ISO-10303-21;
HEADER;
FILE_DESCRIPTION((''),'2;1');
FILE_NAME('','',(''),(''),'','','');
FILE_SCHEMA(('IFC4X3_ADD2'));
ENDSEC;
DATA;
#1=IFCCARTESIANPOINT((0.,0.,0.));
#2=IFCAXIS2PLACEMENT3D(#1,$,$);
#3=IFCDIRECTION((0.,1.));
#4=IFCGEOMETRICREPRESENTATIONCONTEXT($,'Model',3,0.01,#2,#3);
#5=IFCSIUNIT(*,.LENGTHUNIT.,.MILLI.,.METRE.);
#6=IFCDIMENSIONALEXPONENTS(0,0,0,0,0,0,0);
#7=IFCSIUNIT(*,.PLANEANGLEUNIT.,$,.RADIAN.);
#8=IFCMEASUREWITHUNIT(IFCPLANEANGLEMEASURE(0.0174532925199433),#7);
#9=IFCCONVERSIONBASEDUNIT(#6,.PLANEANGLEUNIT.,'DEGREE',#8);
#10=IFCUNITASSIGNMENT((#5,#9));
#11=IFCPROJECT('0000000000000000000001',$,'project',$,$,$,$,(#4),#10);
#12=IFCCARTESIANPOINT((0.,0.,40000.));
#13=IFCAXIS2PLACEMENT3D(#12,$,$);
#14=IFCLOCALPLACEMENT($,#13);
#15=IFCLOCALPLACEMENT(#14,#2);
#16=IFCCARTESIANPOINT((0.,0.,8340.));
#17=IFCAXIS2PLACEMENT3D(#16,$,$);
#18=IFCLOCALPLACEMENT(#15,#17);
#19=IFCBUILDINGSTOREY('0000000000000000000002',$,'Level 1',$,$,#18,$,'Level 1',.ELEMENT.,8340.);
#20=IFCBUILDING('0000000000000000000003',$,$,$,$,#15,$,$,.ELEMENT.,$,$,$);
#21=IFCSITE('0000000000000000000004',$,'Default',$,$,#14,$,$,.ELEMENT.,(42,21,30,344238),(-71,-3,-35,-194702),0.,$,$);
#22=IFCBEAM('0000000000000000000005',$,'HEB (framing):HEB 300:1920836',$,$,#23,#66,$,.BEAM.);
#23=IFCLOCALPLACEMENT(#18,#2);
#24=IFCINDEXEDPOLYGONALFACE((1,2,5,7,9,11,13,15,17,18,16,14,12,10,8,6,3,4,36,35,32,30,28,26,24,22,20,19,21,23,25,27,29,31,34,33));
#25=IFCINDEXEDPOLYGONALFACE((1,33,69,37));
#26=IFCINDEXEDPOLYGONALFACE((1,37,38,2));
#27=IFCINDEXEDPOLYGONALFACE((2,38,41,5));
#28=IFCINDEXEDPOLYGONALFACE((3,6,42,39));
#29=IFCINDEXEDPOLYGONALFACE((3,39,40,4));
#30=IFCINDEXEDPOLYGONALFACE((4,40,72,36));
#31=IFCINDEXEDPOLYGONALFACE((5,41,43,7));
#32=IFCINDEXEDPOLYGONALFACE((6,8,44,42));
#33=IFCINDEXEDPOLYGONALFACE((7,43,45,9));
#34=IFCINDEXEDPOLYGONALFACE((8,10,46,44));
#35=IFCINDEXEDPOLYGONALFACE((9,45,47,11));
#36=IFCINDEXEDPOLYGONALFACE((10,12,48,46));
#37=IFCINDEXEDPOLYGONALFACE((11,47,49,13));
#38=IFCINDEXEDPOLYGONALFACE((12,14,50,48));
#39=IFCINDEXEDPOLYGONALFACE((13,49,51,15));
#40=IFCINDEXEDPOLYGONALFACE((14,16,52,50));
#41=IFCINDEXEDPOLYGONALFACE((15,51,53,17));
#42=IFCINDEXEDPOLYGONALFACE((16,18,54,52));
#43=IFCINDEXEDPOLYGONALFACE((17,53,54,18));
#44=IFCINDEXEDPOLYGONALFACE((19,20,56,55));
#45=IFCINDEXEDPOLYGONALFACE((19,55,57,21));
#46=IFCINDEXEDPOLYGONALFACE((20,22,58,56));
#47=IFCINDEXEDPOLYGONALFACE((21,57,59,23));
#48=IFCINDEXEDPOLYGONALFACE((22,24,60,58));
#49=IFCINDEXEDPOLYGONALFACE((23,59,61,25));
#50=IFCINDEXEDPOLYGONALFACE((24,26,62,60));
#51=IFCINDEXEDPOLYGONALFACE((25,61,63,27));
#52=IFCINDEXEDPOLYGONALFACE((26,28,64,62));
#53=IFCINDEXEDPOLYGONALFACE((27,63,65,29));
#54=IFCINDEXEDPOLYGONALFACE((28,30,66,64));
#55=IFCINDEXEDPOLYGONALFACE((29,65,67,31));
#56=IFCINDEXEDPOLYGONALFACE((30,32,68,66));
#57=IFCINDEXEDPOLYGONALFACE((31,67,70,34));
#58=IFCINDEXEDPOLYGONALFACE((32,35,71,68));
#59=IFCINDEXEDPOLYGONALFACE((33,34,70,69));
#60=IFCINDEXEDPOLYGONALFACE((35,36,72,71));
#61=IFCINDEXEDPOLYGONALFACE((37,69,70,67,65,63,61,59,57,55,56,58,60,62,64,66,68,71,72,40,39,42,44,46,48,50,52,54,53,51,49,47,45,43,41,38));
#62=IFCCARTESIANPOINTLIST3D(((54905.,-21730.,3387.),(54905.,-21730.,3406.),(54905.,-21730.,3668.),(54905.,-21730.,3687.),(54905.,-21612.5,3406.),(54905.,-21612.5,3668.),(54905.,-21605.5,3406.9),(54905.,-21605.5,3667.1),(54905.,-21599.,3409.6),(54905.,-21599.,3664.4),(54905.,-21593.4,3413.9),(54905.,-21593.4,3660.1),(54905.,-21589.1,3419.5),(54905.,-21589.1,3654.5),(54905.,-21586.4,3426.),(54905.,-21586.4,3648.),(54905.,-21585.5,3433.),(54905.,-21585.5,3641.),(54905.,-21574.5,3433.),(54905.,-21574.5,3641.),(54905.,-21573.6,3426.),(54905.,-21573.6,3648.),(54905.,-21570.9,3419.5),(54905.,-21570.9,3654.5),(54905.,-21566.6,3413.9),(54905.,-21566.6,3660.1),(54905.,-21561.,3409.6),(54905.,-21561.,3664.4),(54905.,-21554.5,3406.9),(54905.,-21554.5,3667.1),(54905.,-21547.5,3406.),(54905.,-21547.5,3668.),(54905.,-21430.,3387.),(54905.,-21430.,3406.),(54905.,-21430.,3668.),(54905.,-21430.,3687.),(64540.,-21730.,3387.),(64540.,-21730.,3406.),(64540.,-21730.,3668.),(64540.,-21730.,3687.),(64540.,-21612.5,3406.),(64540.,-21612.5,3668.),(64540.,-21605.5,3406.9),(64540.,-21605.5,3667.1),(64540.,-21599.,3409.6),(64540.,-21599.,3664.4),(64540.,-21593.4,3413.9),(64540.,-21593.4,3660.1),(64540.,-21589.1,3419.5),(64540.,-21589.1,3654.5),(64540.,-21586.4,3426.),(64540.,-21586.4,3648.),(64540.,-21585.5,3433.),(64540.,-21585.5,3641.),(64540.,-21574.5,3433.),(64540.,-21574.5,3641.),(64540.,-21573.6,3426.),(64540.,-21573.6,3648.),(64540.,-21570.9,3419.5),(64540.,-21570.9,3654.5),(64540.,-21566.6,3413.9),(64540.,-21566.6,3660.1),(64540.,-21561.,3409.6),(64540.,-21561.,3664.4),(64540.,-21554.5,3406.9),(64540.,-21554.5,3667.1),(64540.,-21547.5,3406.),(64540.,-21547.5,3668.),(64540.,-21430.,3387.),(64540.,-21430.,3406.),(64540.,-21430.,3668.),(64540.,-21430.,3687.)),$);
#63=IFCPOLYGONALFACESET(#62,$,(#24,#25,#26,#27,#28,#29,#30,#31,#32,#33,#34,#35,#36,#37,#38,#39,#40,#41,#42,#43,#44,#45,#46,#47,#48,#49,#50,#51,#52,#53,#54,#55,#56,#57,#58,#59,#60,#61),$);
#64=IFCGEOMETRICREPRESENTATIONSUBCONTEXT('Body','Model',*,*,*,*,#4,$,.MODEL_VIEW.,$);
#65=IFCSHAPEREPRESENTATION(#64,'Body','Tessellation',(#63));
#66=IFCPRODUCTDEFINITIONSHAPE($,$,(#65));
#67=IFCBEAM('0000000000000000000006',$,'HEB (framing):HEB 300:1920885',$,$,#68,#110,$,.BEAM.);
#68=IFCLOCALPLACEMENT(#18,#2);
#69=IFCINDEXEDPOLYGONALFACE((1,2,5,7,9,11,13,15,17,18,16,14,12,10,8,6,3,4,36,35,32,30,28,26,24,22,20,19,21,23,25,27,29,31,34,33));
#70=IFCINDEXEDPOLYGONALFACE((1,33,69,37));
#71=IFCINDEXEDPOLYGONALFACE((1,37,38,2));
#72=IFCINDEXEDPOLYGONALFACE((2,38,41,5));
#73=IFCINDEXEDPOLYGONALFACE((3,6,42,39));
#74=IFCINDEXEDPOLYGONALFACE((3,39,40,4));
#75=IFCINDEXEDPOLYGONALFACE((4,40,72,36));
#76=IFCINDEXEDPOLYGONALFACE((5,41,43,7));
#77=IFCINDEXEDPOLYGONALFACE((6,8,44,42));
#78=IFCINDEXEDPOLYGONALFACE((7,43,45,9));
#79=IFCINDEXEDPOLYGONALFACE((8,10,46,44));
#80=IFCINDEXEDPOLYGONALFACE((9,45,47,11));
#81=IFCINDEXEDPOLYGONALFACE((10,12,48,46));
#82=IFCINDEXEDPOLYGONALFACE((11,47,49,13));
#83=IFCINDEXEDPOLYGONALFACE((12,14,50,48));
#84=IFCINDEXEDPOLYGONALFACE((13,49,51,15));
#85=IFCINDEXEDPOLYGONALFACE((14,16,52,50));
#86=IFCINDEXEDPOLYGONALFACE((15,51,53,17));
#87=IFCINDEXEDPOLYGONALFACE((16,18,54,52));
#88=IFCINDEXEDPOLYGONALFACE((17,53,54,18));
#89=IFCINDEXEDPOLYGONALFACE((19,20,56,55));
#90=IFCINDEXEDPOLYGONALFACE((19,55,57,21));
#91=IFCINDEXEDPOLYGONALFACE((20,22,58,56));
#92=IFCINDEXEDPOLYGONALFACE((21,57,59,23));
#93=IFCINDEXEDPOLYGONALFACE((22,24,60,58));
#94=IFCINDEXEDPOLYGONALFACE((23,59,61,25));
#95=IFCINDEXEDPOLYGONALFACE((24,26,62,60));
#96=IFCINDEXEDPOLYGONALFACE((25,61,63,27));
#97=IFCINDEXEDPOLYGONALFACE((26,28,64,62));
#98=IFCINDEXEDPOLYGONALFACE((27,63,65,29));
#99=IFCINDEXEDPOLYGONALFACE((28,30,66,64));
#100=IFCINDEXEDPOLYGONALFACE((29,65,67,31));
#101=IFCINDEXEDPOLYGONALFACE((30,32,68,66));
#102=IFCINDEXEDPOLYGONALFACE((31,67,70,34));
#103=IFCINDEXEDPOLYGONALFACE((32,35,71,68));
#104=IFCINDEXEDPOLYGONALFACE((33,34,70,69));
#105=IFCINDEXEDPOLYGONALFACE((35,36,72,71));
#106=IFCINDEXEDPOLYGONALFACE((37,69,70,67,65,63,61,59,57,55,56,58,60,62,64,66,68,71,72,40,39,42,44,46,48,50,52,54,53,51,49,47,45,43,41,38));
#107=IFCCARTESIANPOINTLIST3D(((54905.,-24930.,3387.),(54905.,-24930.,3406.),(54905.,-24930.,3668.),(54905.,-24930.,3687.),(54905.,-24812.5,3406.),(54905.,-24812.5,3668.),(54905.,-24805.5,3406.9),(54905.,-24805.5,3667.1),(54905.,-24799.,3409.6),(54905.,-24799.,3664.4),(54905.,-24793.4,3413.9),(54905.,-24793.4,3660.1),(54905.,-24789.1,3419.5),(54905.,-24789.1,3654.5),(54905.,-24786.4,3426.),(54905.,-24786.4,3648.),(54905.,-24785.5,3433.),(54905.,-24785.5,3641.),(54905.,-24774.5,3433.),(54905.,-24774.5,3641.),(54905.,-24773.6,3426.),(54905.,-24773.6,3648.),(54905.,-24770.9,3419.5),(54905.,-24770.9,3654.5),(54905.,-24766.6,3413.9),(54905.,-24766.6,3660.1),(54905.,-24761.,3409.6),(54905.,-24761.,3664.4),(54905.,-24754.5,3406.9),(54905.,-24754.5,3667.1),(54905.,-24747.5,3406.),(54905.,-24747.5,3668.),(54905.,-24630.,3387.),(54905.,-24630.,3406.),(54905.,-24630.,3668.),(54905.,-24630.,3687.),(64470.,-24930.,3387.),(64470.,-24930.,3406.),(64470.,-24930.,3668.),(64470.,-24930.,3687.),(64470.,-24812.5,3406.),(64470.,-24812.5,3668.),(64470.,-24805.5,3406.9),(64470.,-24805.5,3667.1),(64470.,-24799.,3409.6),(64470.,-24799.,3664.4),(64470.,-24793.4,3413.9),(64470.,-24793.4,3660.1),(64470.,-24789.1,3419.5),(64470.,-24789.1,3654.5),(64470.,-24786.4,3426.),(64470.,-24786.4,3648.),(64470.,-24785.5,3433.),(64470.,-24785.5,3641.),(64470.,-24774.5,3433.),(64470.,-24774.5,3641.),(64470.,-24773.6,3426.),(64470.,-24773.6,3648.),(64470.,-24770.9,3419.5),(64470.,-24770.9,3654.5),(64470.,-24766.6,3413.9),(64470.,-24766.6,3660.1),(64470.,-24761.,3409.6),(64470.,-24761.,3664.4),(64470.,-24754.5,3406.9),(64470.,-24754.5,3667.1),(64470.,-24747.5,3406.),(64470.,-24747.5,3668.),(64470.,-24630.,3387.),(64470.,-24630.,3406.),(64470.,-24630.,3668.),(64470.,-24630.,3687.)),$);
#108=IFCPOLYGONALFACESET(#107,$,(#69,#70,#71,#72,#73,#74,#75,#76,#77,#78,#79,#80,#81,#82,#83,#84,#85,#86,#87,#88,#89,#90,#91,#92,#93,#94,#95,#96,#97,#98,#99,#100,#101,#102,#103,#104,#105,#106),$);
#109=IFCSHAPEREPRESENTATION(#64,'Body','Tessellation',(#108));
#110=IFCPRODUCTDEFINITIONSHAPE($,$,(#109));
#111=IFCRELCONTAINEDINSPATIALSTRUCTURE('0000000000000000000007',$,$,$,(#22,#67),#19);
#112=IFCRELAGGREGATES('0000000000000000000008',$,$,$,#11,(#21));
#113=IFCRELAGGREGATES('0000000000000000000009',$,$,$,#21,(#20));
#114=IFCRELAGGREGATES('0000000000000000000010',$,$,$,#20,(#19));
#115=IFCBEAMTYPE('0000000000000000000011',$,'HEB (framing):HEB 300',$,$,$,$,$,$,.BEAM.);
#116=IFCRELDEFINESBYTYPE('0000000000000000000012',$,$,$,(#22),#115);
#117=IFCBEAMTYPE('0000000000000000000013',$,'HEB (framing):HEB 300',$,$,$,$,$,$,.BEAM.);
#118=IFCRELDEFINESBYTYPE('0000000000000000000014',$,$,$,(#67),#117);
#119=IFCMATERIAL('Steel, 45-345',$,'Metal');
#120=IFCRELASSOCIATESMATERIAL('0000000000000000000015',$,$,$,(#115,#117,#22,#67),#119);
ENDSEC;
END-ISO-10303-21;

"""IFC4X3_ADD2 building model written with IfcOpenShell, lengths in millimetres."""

from ifc_helpers import new_model, entity, si_unit, converted_unit, direction, frame, frame_2d, origin, place, context, subcontext, project, spatial, polyline, circle_curve, parameter, trimmed, segment, composite_curve, outline, extrude, source, transform, mapped, material, material_profile, profile_set, profile_usage, type_object, type_shapes, element, save


model = new_model("IFC4X3_ADD2")

# Units and contexts
model_context = context("Model", 3, precision=0.01, world=origin(), true_north=direction((0.0, 1.0)))
body_context = subcontext(model_context, "Body", "Model", "MODEL_VIEW")
ifc_project = project(units=[si_unit("LENGTHUNIT", "METRE", prefix="MILLI"), converted_unit("PLANEANGLEUNIT", "DEGREE", entity("IfcPlaneAngleMeasure", 0.0174532925199433), si_unit("PLANEANGLEUNIT", "RADIAN"), dimensions=[0, 0, 0, 0, 0, 0, 0])], contexts=[model_context])

# Site, building, storey
site_placement = place(None, frame((0.0, 0.0, 40000.0)))
site = spatial("IfcSite", under=ifc_project, at=site_placement, Name="Default", CompositionType="ELEMENT", RefLatitude=(42, 21, 30, 344238), RefLongitude=(-71, -3, -35, -194702), RefElevation=0.0)
building_placement = place(site_placement, origin())
building = spatial("IfcBuilding", under=site, at=building_placement, CompositionType="ELEMENT")
storey_placement = place(building_placement, frame((0.0, 0.0, 8340.0)))
storey = spatial("IfcBuildingStorey", under=building, at=storey_placement, Name="Level 1", LongName="Level 1", CompositionType="ELEMENT", Elevation=8340.0)

# Shared definitions
ifc_material_1 = material(Name="Steel, 45-345", Category="Metal")

# Beams
ifc_material_profile_1 = material_profile(ifc_material_1, outline(composite_curve([segment(polyline([(-150.0, -131.0), (-150.0, -150.0)]), True, "CONTINUOUS"), segment(polyline([(-150.0, -150.0), (150.0, -150.0)]), True, "CONTINUOUS"), segment(polyline([(150.0, -150.0), (150.0, -131.0)]), True, "CONTINUOUS"), segment(polyline([(150.0, -131.0), (32.5, -131.0)]), True, "CONTINUOUS"), segment(trimmed(circle_curve(frame_2d((32.5, -104.0), x_axis=(1.0, 0.0)), 27.0), [parameter(180.0)], [parameter(270.0)], True, "PARAMETER"), False, "CONTINUOUS"), segment(polyline([(5.5, -104.0), (5.5, 104.0)]), True, "CONTINUOUS"), segment(trimmed(circle_curve(frame_2d((32.5, 104.0), x_axis=(1.0, 0.0)), 27.0), [parameter(90.0)], [parameter(180.0)], True, "PARAMETER"), False, "CONTINUOUS"), segment(polyline([(32.5, 131.0), (150.0, 131.0)]), True, "CONTINUOUS"), segment(polyline([(150.0, 131.0), (150.0, 150.0)]), True, "CONTINUOUS"), segment(polyline([(150.0, 150.0), (-150.0, 150.0)]), True, "CONTINUOUS"), segment(polyline([(-150.0, 150.0), (-150.0, 131.0)]), True, "CONTINUOUS"), segment(polyline([(-150.0, 131.0), (-32.5, 131.0)]), True, "CONTINUOUS"), segment(trimmed(circle_curve(frame_2d((-32.5, 104.0), x_axis=(1.0, 0.0)), 27.0), [parameter(360.0)], [parameter(90.0)], True, "PARAMETER"), False, "CONTINUOUS"), segment(polyline([(-5.5, 104.0), (-5.5, -104.0)]), True, "CONTINUOUS"), segment(trimmed(circle_curve(frame_2d((-32.5, -104.0), x_axis=(1.0, 0.0)), 27.0), [parameter(270.0)], [parameter(0.0)], True, "PARAMETER"), False, "CONTINUOUS"), segment(polyline([(-32.5, -131.0), (-150.0, -131.0)]), True, "CONTINUOUS")], self_intersect=False)), Name="HEB 300")
ifc_profile_set_1 = profile_set([ifc_material_profile_1], Name="HEB 300")
ifc_profile_usage_1 = profile_usage(ifc_profile_set_1, cardinal=8)
beam_type_1 = type_object("IfcBeamType", Name="HEB (framing):HEB 300", PredefinedType="BEAM", material=ifc_profile_set_1)
shared_shape_1 = source(origin(), body_context, "Body", "SweptSolid", [
    extrude(outline(composite_curve([segment(polyline([(-150.0, -131.0), (-150.0, -150.0)]), True, "CONTINUOUS"), segment(polyline([(-150.0, -150.0), (150.0, -150.0)]), True, "CONTINUOUS"), segment(polyline([(150.0, -150.0), (150.0, -131.0)]), True, "CONTINUOUS"), segment(polyline([(150.0, -131.0), (32.5, -131.0)]), True, "CONTINUOUS"), segment(trimmed(circle_curve(frame_2d((32.5, -104.0), x_axis=(1.0, 0.0)), 27.0), [parameter(180.0)], [parameter(270.0)], True, "PARAMETER"), False, "CONTINUOUS"), segment(polyline([(5.5, -104.0), (5.5, 104.0)]), True, "CONTINUOUS"), segment(trimmed(circle_curve(frame_2d((32.5, 104.0), x_axis=(1.0, 0.0)), 27.0), [parameter(90.0)], [parameter(180.0)], True, "PARAMETER"), False, "CONTINUOUS"), segment(polyline([(32.5, 131.0), (150.0, 131.0)]), True, "CONTINUOUS"), segment(polyline([(150.0, 131.0), (150.0, 150.0)]), True, "CONTINUOUS"), segment(polyline([(150.0, 150.0), (-150.0, 150.0)]), True, "CONTINUOUS"), segment(polyline([(-150.0, 150.0), (-150.0, 131.0)]), True, "CONTINUOUS"), segment(polyline([(-150.0, 131.0), (-32.5, 131.0)]), True, "CONTINUOUS"), segment(trimmed(circle_curve(frame_2d((-32.5, 104.0), x_axis=(1.0, 0.0)), 27.0), [parameter(360.0)], [parameter(90.0)], True, "PARAMETER"), False, "CONTINUOUS"), segment(polyline([(-5.5, 104.0), (-5.5, -104.0)]), True, "CONTINUOUS"), segment(trimmed(circle_curve(frame_2d((-32.5, -104.0), x_axis=(1.0, 0.0)), 27.0), [parameter(270.0)], [parameter(0.0)], True, "PARAMETER"), False, "CONTINUOUS"), segment(polyline([(-32.5, -131.0), (-150.0, -131.0)]), True, "CONTINUOUS")], self_intersect=False)), frame((-4782.5, 0.0, 0.0), z_axis=(-1.0, 0.0, 0.0), x_axis=(0.0, -1.0, 0.0)), (0.0, 0.0, -1.0), 9635.0),
])
type_shapes(beam_type_1, [shared_shape_1])
for number, where, name in (
    (1, (59687.5, -21580.0, 3537.0), "HEB (framing):HEB 300:1920836"),
):
    element("IfcBeam", number, at=place(storey_placement, frame(where)), inside=storey, type_object=beam_type_1, material=ifc_profile_usage_1, Name=name, PredefinedType="BEAM", context=body_context, shape_type="MappedRepresentation", body=[
        mapped(shared_shape_1, transform((0.0, 0.0, 0.0), scale=1.0)),
    ])
beam_type_2 = type_object("IfcBeamType", Name="HEB (framing):HEB 300", PredefinedType="BEAM", material=ifc_profile_set_1)
shared_shape_2 = source(origin(), body_context, "Body", "SweptSolid", [
    extrude(outline(composite_curve([segment(polyline([(-150.0, -131.0), (-150.0, -150.0)]), True, "CONTINUOUS"), segment(polyline([(-150.0, -150.0), (150.0, -150.0)]), True, "CONTINUOUS"), segment(polyline([(150.0, -150.0), (150.0, -131.0)]), True, "CONTINUOUS"), segment(polyline([(150.0, -131.0), (32.5, -131.0)]), True, "CONTINUOUS"), segment(trimmed(circle_curve(frame_2d((32.5, -104.0), x_axis=(1.0, 0.0)), 27.0), [parameter(180.0)], [parameter(270.0)], True, "PARAMETER"), False, "CONTINUOUS"), segment(polyline([(5.5, -104.0), (5.5, 104.0)]), True, "CONTINUOUS"), segment(trimmed(circle_curve(frame_2d((32.5, 104.0), x_axis=(1.0, 0.0)), 27.0), [parameter(90.0)], [parameter(180.0)], True, "PARAMETER"), False, "CONTINUOUS"), segment(polyline([(32.5, 131.0), (150.0, 131.0)]), True, "CONTINUOUS"), segment(polyline([(150.0, 131.0), (150.0, 150.0)]), True, "CONTINUOUS"), segment(polyline([(150.0, 150.0), (-150.0, 150.0)]), True, "CONTINUOUS"), segment(polyline([(-150.0, 150.0), (-150.0, 131.0)]), True, "CONTINUOUS"), segment(polyline([(-150.0, 131.0), (-32.5, 131.0)]), True, "CONTINUOUS"), segment(trimmed(circle_curve(frame_2d((-32.5, 104.0), x_axis=(1.0, 0.0)), 27.0), [parameter(360.0)], [parameter(90.0)], True, "PARAMETER"), False, "CONTINUOUS"), segment(polyline([(-5.5, 104.0), (-5.5, -104.0)]), True, "CONTINUOUS"), segment(trimmed(circle_curve(frame_2d((-32.5, -104.0), x_axis=(1.0, 0.0)), 27.0), [parameter(270.0)], [parameter(0.0)], True, "PARAMETER"), False, "CONTINUOUS"), segment(polyline([(-32.5, -131.0), (-150.0, -131.0)]), True, "CONTINUOUS")], self_intersect=False)), frame((-4697.5, 0.0, 0.0), z_axis=(-1.0, 0.0, 0.0), x_axis=(0.0, -1.0, 0.0)), (0.0, 0.0, -1.0), 9565.0),
])
type_shapes(beam_type_2, [shared_shape_2])
beam_1_placement = place(storey_placement, frame((59602.5, -24780.0, 3537.0)))
element("IfcBeam", 2, at=beam_1_placement, inside=storey, type_object=beam_type_2, material=ifc_profile_usage_1, Name="HEB (framing):HEB 300:1920885", PredefinedType="BEAM", context=body_context, shape_type="MappedRepresentation", body=[
    mapped(shared_shape_2, transform((0.0, 0.0, 0.0), scale=1.0)),
])

save(model, "model.ifc")
